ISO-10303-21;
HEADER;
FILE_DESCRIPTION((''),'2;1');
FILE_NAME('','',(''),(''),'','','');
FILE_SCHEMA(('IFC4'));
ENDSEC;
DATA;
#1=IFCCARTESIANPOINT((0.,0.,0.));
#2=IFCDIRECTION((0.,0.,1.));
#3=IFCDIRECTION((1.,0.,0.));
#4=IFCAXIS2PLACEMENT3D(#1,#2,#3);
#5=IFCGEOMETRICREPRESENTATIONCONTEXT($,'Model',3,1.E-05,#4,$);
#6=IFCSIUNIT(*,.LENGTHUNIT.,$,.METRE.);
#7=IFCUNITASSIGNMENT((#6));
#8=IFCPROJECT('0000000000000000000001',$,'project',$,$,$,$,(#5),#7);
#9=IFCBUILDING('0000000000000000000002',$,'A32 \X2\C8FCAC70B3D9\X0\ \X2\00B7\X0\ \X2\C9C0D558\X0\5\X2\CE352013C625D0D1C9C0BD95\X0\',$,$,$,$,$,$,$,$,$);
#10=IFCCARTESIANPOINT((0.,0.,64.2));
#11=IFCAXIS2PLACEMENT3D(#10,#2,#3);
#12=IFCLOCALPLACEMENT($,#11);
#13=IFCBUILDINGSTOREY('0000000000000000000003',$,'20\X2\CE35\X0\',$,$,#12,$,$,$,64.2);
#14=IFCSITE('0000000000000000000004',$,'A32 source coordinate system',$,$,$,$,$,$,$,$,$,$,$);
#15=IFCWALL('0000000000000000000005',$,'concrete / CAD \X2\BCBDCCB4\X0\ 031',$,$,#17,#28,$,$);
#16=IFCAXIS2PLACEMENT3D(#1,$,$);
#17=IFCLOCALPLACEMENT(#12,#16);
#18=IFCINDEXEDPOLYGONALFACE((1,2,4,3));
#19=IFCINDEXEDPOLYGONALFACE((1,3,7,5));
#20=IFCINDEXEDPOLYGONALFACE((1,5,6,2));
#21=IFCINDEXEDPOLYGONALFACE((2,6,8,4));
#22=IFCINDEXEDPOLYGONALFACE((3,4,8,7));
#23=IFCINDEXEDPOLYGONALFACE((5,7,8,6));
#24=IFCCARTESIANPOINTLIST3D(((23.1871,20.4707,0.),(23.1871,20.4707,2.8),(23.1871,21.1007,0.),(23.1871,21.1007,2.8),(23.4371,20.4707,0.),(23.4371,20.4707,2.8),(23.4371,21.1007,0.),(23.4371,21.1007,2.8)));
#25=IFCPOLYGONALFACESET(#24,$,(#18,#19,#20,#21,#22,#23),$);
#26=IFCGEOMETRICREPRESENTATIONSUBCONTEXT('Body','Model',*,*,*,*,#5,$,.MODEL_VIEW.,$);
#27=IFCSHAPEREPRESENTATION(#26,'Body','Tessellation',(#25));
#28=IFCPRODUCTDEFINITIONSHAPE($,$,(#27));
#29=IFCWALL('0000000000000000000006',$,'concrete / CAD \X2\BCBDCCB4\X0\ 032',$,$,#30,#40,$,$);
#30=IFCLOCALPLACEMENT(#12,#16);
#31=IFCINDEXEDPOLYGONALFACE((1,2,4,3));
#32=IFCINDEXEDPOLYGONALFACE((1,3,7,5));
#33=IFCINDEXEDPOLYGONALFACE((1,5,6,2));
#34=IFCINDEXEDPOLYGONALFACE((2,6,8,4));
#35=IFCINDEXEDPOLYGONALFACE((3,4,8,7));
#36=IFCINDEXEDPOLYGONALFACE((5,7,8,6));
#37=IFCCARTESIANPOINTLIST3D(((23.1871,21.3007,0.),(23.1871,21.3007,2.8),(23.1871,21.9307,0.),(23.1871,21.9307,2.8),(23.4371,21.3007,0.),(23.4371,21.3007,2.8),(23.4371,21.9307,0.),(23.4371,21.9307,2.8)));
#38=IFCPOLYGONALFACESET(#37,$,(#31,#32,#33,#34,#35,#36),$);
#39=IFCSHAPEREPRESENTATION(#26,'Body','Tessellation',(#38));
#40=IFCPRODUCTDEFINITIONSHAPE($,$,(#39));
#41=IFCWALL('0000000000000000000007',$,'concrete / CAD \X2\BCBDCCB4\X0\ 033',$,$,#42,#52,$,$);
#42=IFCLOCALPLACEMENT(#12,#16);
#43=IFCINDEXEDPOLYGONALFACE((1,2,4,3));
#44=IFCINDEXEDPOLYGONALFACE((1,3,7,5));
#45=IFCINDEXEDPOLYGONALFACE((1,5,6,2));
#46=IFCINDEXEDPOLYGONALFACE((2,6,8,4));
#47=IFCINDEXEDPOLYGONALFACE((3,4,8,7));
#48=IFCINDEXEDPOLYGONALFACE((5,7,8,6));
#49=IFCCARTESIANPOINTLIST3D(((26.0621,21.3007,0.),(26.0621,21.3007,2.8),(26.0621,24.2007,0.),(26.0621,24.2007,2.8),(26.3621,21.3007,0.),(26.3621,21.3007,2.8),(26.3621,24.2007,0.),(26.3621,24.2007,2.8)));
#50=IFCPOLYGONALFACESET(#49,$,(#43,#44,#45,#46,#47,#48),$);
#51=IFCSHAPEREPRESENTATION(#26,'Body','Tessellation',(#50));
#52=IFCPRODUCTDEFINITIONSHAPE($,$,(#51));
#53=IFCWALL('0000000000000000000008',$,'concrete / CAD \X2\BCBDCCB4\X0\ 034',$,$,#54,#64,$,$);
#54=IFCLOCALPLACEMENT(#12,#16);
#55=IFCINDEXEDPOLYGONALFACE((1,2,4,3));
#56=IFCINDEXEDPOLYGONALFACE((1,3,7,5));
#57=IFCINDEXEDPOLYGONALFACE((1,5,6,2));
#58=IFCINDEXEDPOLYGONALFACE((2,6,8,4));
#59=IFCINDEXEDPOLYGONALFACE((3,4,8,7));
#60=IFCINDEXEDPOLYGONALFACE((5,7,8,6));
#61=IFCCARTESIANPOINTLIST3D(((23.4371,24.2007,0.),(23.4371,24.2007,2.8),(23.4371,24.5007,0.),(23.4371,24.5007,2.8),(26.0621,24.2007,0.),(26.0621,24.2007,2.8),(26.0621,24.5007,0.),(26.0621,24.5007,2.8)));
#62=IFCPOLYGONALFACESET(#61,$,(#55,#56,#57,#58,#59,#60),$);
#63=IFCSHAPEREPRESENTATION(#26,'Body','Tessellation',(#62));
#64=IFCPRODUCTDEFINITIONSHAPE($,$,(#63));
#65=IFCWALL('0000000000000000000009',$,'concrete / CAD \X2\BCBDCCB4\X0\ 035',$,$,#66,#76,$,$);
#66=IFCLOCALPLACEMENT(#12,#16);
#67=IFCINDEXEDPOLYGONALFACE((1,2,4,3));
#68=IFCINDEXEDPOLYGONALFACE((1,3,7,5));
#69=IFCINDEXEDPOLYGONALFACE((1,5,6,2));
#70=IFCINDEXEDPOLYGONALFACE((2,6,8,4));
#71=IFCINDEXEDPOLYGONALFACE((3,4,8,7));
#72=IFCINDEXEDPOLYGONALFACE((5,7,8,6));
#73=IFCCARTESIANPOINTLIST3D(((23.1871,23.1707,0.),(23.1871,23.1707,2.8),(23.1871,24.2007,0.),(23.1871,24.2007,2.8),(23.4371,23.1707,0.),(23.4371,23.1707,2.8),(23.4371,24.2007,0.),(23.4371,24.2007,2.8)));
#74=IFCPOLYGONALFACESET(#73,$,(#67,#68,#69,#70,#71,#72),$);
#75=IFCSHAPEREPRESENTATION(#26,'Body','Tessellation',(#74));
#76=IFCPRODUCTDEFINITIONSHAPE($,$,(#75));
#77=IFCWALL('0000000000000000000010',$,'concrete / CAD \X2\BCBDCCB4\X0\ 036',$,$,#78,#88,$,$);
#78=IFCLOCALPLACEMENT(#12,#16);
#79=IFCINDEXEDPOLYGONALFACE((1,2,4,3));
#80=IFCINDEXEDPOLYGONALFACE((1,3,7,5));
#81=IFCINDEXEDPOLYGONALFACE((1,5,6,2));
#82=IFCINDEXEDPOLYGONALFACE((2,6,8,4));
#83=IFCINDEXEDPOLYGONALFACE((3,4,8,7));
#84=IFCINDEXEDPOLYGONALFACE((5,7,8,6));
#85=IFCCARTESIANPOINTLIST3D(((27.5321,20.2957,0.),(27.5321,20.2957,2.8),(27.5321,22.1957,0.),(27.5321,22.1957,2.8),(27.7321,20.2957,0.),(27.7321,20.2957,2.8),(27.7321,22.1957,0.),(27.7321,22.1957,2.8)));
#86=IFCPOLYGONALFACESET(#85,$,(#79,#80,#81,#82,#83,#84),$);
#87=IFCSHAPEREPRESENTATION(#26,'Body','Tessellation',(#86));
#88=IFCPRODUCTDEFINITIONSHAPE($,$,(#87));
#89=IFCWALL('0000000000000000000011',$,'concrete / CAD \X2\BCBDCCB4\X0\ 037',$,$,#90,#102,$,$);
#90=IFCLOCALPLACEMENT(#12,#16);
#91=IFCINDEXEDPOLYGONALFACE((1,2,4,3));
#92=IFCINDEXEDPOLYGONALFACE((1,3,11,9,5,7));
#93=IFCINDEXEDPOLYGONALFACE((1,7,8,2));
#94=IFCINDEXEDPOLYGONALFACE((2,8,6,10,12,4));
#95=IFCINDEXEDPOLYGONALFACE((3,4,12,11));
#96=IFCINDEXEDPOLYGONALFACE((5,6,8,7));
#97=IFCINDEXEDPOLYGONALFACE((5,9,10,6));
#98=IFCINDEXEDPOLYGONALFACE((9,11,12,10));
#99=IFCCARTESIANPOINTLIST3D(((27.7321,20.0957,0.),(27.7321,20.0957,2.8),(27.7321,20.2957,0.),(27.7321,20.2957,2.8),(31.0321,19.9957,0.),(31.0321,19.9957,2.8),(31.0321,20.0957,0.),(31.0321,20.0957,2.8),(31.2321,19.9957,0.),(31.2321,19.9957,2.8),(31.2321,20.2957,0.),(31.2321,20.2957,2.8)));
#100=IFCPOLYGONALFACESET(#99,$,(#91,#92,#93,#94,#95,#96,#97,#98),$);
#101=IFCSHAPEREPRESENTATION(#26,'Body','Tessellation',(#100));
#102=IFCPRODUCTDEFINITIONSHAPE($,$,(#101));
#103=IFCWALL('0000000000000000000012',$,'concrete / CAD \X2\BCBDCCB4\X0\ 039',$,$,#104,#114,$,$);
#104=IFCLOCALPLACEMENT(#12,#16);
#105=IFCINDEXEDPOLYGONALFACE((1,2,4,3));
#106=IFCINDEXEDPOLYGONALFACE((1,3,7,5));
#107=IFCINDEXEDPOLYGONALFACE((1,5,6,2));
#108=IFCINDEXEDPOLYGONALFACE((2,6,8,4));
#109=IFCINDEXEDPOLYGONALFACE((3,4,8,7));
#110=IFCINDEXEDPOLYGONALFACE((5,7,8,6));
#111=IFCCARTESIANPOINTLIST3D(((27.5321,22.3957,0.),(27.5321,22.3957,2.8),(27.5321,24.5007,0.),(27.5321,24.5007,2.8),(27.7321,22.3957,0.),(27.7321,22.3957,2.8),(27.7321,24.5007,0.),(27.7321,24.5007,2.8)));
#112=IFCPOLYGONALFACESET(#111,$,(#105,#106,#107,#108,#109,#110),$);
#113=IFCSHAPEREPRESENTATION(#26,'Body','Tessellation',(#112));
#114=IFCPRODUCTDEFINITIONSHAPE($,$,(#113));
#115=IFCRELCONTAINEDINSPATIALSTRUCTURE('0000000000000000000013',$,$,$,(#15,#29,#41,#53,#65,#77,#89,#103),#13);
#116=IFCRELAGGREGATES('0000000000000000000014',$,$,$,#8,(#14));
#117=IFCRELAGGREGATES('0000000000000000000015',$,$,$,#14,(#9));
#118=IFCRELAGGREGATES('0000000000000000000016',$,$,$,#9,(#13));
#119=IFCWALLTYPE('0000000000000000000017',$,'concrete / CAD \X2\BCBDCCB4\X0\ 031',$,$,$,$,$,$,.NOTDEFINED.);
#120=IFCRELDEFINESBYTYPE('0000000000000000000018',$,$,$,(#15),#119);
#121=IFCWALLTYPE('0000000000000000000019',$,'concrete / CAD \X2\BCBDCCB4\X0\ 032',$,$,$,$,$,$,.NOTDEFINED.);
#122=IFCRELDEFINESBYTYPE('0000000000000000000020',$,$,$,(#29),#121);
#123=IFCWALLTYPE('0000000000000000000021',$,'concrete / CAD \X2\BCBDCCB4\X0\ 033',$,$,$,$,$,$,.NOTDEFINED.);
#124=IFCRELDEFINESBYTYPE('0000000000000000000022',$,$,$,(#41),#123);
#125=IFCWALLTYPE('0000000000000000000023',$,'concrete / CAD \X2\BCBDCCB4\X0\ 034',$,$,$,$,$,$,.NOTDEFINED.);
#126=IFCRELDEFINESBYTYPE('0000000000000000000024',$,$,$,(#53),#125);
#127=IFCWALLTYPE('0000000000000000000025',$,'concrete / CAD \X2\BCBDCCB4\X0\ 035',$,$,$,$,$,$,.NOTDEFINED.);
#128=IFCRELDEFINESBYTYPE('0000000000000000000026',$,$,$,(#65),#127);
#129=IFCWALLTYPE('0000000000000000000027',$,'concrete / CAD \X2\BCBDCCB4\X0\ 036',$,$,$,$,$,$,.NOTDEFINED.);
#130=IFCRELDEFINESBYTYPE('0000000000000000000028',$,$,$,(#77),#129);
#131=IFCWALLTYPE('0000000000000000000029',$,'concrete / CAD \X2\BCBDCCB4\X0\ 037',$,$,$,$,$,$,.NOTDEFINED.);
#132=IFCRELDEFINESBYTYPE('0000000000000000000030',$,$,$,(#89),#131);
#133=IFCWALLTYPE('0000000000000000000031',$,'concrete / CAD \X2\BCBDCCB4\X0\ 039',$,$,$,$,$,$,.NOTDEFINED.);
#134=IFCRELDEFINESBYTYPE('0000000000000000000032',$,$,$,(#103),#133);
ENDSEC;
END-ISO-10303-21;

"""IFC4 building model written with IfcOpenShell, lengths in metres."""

from ifc_helpers import new_model, si_unit, frame, origin, origin_with_axes, place, context, subcontext, project, spatial, polyline, outline, extrude, source, transform, mapped, type_object, type_shapes, element, save


model = new_model("IFC4")

# Units and contexts
model_context = context("Model", 3, precision=1e-05, world=origin_with_axes())
body_context = subcontext(model_context, "Body", "Model", "MODEL_VIEW")
ifc_project = project(units=[si_unit("LENGTHUNIT", "METRE")], contexts=[model_context])

# Site, building, storey
site = spatial("IfcSite", under=ifc_project, Name="A32 source coordinate system")
building = spatial("IfcBuilding", under=site, Name="A32 주거동 · 지하5층–옥탑지붕")
storey_placement = place(None, frame((0.0, 0.0, 64.2), z_axis=(0.0, 0.0, 1.0), x_axis=(1.0, 0.0, 0.0)))
storey = spatial("IfcBuildingStorey", under=building, at=storey_placement, Name="20층", Elevation=64.2)

# Walls
wall_type_1 = type_object("IfcWallType", Name="concrete / CAD 벽체 031", PredefinedType="NOTDEFINED")
shared_shape_1 = source(origin(), body_context, "Body", "SweptSolid", [
    extrude(outline(polyline([(23.1871, 20.4707), (23.1871, 21.1007), (23.4371, 21.1007), (23.4371, 20.4707), (23.1871, 20.4707)])), origin(), (0.0, 0.0, 1.0), 2.8),
])
type_shapes(wall_type_1, [shared_shape_1])
wall_1_placement = place(storey_placement, origin_with_axes())
element("IfcWall", 1, at=wall_1_placement, inside=storey, type_object=wall_type_1, Name="concrete / CAD 벽체 031", context=body_context, shape_type="MappedRepresentation", body=[
    mapped(shared_shape_1, transform((0.0, 0.0, 0.0), scale=1.0)),
])
wall_type_2 = type_object("IfcWallType", Name="concrete / CAD 벽체 032", PredefinedType="NOTDEFINED")
shared_shape_2 = source(origin(), body_context, "Body", "SweptSolid", [
    extrude(outline(polyline([(23.4371, 21.9307), (23.4371, 21.3007), (23.1871, 21.3007), (23.1871, 21.9307), (23.4371, 21.9307)])), origin(), (0.0, 0.0, 1.0), 2.8),
])
type_shapes(wall_type_2, [shared_shape_2])
wall_2_placement = place(storey_placement, origin_with_axes())
element("IfcWall", 2, at=wall_2_placement, inside=storey, type_object=wall_type_2, Name="concrete / CAD 벽체 032", context=body_context, shape_type="MappedRepresentation", body=[
    mapped(shared_shape_2, transform((0.0, 0.0, 0.0), scale=1.0)),
])
wall_type_3 = type_object("IfcWallType", Name="concrete / CAD 벽체 033", PredefinedType="NOTDEFINED")
shared_shape_3 = source(origin(), body_context, "Body", "SweptSolid", [
    extrude(outline(polyline([(26.3621, 24.2007), (26.3621, 21.3007), (26.0621, 21.3007), (26.0621, 24.2007), (26.3621, 24.2007)])), origin(), (0.0, 0.0, 1.0), 2.8),
])
type_shapes(wall_type_3, [shared_shape_3])
wall_3_placement = place(storey_placement, origin_with_axes())
element("IfcWall", 3, at=wall_3_placement, inside=storey, type_object=wall_type_3, Name="concrete / CAD 벽체 033", context=body_context, shape_type="MappedRepresentation", body=[
    mapped(shared_shape_3, transform((0.0, 0.0, 0.0), scale=1.0)),
])
wall_type_4 = type_object("IfcWallType", Name="concrete / CAD 벽체 034", PredefinedType="NOTDEFINED")
shared_shape_4 = source(origin(), body_context, "Body", "SweptSolid", [
    extrude(outline(polyline([(23.4371, 24.5007), (26.0621, 24.5007), (26.0621, 24.2007), (23.4371, 24.2007), (23.4371, 24.5007)])), origin(), (0.0, 0.0, 1.0), 2.8),
])
type_shapes(wall_type_4, [shared_shape_4])
wall_4_placement = place(storey_placement, origin_with_axes())
element("IfcWall", 4, at=wall_4_placement, inside=storey, type_object=wall_type_4, Name="concrete / CAD 벽체 034", context=body_context, shape_type="MappedRepresentation", body=[
    mapped(shared_shape_4, transform((0.0, 0.0, 0.0), scale=1.0)),
])
wall_type_5 = type_object("IfcWallType", Name="concrete / CAD 벽체 035", PredefinedType="NOTDEFINED")
shared_shape_5 = source(origin(), body_context, "Body", "SweptSolid", [
    extrude(outline(polyline([(23.1871, 23.1707), (23.1871, 24.2007), (23.4371, 24.2007), (23.4371, 23.1707), (23.1871, 23.1707)])), origin(), (0.0, 0.0, 1.0), 2.8),
])
type_shapes(wall_type_5, [shared_shape_5])
wall_5_placement = place(storey_placement, origin_with_axes())
element("IfcWall", 5, at=wall_5_placement, inside=storey, type_object=wall_type_5, Name="concrete / CAD 벽체 035", context=body_context, shape_type="MappedRepresentation", body=[
    mapped(shared_shape_5, transform((0.0, 0.0, 0.0), scale=1.0)),
])
wall_type_6 = type_object("IfcWallType", Name="concrete / CAD 벽체 036", PredefinedType="NOTDEFINED")
shared_shape_6 = source(origin(), body_context, "Body", "SweptSolid", [
    extrude(outline(polyline([(27.7321, 22.1957), (27.7321, 20.2957), (27.5321, 20.2957), (27.5321, 22.1957), (27.7321, 22.1957)])), origin(), (0.0, 0.0, 1.0), 2.8),
])
type_shapes(wall_type_6, [shared_shape_6])
wall_6_placement = place(storey_placement, origin_with_axes())
element("IfcWall", 6, at=wall_6_placement, inside=storey, type_object=wall_type_6, Name="concrete / CAD 벽체 036", context=body_context, shape_type="MappedRepresentation", body=[
    mapped(shared_shape_6, transform((0.0, 0.0, 0.0), scale=1.0)),
])
wall_type_7 = type_object("IfcWallType", Name="concrete / CAD 벽체 037", PredefinedType="NOTDEFINED")
shared_shape_7 = source(origin(), body_context, "Body", "SweptSolid", [
    extrude(outline(polyline([(31.2321, 19.9957), (31.0321, 19.9957), (31.0321, 20.0957), (27.7321, 20.0957), (27.7321, 20.2957), (31.2321, 20.2957), (31.2321, 19.9957)])), origin(), (0.0, 0.0, 1.0), 2.8),
])
type_shapes(wall_type_7, [shared_shape_7])
wall_7_placement = place(storey_placement, origin_with_axes())
element("IfcWall", 7, at=wall_7_placement, inside=storey, type_object=wall_type_7, Name="concrete / CAD 벽체 037", context=body_context, shape_type="MappedRepresentation", body=[
    mapped(shared_shape_7, transform((0.0, 0.0, 0.0), scale=1.0)),
])
wall_type_8 = type_object("IfcWallType", Name="concrete / CAD 벽체 039", PredefinedType="NOTDEFINED")
shared_shape_8 = source(origin(), body_context, "Body", "SweptSolid", [
    extrude(outline(polyline([(27.7321, 24.5007), (27.7321, 22.3957), (27.5321, 22.3957), (27.5321, 24.5007), (27.7321, 24.5007)])), origin(), (0.0, 0.0, 1.0), 2.8),
])
type_shapes(wall_type_8, [shared_shape_8])
wall_8_placement = place(storey_placement, origin_with_axes())
element("IfcWall", 8, at=wall_8_placement, inside=storey, type_object=wall_type_8, Name="concrete / CAD 벽체 039", context=body_context, shape_type="MappedRepresentation", body=[
    mapped(shared_shape_8, transform((0.0, 0.0, 0.0), scale=1.0)),
])

save(model, "model.ifc")
